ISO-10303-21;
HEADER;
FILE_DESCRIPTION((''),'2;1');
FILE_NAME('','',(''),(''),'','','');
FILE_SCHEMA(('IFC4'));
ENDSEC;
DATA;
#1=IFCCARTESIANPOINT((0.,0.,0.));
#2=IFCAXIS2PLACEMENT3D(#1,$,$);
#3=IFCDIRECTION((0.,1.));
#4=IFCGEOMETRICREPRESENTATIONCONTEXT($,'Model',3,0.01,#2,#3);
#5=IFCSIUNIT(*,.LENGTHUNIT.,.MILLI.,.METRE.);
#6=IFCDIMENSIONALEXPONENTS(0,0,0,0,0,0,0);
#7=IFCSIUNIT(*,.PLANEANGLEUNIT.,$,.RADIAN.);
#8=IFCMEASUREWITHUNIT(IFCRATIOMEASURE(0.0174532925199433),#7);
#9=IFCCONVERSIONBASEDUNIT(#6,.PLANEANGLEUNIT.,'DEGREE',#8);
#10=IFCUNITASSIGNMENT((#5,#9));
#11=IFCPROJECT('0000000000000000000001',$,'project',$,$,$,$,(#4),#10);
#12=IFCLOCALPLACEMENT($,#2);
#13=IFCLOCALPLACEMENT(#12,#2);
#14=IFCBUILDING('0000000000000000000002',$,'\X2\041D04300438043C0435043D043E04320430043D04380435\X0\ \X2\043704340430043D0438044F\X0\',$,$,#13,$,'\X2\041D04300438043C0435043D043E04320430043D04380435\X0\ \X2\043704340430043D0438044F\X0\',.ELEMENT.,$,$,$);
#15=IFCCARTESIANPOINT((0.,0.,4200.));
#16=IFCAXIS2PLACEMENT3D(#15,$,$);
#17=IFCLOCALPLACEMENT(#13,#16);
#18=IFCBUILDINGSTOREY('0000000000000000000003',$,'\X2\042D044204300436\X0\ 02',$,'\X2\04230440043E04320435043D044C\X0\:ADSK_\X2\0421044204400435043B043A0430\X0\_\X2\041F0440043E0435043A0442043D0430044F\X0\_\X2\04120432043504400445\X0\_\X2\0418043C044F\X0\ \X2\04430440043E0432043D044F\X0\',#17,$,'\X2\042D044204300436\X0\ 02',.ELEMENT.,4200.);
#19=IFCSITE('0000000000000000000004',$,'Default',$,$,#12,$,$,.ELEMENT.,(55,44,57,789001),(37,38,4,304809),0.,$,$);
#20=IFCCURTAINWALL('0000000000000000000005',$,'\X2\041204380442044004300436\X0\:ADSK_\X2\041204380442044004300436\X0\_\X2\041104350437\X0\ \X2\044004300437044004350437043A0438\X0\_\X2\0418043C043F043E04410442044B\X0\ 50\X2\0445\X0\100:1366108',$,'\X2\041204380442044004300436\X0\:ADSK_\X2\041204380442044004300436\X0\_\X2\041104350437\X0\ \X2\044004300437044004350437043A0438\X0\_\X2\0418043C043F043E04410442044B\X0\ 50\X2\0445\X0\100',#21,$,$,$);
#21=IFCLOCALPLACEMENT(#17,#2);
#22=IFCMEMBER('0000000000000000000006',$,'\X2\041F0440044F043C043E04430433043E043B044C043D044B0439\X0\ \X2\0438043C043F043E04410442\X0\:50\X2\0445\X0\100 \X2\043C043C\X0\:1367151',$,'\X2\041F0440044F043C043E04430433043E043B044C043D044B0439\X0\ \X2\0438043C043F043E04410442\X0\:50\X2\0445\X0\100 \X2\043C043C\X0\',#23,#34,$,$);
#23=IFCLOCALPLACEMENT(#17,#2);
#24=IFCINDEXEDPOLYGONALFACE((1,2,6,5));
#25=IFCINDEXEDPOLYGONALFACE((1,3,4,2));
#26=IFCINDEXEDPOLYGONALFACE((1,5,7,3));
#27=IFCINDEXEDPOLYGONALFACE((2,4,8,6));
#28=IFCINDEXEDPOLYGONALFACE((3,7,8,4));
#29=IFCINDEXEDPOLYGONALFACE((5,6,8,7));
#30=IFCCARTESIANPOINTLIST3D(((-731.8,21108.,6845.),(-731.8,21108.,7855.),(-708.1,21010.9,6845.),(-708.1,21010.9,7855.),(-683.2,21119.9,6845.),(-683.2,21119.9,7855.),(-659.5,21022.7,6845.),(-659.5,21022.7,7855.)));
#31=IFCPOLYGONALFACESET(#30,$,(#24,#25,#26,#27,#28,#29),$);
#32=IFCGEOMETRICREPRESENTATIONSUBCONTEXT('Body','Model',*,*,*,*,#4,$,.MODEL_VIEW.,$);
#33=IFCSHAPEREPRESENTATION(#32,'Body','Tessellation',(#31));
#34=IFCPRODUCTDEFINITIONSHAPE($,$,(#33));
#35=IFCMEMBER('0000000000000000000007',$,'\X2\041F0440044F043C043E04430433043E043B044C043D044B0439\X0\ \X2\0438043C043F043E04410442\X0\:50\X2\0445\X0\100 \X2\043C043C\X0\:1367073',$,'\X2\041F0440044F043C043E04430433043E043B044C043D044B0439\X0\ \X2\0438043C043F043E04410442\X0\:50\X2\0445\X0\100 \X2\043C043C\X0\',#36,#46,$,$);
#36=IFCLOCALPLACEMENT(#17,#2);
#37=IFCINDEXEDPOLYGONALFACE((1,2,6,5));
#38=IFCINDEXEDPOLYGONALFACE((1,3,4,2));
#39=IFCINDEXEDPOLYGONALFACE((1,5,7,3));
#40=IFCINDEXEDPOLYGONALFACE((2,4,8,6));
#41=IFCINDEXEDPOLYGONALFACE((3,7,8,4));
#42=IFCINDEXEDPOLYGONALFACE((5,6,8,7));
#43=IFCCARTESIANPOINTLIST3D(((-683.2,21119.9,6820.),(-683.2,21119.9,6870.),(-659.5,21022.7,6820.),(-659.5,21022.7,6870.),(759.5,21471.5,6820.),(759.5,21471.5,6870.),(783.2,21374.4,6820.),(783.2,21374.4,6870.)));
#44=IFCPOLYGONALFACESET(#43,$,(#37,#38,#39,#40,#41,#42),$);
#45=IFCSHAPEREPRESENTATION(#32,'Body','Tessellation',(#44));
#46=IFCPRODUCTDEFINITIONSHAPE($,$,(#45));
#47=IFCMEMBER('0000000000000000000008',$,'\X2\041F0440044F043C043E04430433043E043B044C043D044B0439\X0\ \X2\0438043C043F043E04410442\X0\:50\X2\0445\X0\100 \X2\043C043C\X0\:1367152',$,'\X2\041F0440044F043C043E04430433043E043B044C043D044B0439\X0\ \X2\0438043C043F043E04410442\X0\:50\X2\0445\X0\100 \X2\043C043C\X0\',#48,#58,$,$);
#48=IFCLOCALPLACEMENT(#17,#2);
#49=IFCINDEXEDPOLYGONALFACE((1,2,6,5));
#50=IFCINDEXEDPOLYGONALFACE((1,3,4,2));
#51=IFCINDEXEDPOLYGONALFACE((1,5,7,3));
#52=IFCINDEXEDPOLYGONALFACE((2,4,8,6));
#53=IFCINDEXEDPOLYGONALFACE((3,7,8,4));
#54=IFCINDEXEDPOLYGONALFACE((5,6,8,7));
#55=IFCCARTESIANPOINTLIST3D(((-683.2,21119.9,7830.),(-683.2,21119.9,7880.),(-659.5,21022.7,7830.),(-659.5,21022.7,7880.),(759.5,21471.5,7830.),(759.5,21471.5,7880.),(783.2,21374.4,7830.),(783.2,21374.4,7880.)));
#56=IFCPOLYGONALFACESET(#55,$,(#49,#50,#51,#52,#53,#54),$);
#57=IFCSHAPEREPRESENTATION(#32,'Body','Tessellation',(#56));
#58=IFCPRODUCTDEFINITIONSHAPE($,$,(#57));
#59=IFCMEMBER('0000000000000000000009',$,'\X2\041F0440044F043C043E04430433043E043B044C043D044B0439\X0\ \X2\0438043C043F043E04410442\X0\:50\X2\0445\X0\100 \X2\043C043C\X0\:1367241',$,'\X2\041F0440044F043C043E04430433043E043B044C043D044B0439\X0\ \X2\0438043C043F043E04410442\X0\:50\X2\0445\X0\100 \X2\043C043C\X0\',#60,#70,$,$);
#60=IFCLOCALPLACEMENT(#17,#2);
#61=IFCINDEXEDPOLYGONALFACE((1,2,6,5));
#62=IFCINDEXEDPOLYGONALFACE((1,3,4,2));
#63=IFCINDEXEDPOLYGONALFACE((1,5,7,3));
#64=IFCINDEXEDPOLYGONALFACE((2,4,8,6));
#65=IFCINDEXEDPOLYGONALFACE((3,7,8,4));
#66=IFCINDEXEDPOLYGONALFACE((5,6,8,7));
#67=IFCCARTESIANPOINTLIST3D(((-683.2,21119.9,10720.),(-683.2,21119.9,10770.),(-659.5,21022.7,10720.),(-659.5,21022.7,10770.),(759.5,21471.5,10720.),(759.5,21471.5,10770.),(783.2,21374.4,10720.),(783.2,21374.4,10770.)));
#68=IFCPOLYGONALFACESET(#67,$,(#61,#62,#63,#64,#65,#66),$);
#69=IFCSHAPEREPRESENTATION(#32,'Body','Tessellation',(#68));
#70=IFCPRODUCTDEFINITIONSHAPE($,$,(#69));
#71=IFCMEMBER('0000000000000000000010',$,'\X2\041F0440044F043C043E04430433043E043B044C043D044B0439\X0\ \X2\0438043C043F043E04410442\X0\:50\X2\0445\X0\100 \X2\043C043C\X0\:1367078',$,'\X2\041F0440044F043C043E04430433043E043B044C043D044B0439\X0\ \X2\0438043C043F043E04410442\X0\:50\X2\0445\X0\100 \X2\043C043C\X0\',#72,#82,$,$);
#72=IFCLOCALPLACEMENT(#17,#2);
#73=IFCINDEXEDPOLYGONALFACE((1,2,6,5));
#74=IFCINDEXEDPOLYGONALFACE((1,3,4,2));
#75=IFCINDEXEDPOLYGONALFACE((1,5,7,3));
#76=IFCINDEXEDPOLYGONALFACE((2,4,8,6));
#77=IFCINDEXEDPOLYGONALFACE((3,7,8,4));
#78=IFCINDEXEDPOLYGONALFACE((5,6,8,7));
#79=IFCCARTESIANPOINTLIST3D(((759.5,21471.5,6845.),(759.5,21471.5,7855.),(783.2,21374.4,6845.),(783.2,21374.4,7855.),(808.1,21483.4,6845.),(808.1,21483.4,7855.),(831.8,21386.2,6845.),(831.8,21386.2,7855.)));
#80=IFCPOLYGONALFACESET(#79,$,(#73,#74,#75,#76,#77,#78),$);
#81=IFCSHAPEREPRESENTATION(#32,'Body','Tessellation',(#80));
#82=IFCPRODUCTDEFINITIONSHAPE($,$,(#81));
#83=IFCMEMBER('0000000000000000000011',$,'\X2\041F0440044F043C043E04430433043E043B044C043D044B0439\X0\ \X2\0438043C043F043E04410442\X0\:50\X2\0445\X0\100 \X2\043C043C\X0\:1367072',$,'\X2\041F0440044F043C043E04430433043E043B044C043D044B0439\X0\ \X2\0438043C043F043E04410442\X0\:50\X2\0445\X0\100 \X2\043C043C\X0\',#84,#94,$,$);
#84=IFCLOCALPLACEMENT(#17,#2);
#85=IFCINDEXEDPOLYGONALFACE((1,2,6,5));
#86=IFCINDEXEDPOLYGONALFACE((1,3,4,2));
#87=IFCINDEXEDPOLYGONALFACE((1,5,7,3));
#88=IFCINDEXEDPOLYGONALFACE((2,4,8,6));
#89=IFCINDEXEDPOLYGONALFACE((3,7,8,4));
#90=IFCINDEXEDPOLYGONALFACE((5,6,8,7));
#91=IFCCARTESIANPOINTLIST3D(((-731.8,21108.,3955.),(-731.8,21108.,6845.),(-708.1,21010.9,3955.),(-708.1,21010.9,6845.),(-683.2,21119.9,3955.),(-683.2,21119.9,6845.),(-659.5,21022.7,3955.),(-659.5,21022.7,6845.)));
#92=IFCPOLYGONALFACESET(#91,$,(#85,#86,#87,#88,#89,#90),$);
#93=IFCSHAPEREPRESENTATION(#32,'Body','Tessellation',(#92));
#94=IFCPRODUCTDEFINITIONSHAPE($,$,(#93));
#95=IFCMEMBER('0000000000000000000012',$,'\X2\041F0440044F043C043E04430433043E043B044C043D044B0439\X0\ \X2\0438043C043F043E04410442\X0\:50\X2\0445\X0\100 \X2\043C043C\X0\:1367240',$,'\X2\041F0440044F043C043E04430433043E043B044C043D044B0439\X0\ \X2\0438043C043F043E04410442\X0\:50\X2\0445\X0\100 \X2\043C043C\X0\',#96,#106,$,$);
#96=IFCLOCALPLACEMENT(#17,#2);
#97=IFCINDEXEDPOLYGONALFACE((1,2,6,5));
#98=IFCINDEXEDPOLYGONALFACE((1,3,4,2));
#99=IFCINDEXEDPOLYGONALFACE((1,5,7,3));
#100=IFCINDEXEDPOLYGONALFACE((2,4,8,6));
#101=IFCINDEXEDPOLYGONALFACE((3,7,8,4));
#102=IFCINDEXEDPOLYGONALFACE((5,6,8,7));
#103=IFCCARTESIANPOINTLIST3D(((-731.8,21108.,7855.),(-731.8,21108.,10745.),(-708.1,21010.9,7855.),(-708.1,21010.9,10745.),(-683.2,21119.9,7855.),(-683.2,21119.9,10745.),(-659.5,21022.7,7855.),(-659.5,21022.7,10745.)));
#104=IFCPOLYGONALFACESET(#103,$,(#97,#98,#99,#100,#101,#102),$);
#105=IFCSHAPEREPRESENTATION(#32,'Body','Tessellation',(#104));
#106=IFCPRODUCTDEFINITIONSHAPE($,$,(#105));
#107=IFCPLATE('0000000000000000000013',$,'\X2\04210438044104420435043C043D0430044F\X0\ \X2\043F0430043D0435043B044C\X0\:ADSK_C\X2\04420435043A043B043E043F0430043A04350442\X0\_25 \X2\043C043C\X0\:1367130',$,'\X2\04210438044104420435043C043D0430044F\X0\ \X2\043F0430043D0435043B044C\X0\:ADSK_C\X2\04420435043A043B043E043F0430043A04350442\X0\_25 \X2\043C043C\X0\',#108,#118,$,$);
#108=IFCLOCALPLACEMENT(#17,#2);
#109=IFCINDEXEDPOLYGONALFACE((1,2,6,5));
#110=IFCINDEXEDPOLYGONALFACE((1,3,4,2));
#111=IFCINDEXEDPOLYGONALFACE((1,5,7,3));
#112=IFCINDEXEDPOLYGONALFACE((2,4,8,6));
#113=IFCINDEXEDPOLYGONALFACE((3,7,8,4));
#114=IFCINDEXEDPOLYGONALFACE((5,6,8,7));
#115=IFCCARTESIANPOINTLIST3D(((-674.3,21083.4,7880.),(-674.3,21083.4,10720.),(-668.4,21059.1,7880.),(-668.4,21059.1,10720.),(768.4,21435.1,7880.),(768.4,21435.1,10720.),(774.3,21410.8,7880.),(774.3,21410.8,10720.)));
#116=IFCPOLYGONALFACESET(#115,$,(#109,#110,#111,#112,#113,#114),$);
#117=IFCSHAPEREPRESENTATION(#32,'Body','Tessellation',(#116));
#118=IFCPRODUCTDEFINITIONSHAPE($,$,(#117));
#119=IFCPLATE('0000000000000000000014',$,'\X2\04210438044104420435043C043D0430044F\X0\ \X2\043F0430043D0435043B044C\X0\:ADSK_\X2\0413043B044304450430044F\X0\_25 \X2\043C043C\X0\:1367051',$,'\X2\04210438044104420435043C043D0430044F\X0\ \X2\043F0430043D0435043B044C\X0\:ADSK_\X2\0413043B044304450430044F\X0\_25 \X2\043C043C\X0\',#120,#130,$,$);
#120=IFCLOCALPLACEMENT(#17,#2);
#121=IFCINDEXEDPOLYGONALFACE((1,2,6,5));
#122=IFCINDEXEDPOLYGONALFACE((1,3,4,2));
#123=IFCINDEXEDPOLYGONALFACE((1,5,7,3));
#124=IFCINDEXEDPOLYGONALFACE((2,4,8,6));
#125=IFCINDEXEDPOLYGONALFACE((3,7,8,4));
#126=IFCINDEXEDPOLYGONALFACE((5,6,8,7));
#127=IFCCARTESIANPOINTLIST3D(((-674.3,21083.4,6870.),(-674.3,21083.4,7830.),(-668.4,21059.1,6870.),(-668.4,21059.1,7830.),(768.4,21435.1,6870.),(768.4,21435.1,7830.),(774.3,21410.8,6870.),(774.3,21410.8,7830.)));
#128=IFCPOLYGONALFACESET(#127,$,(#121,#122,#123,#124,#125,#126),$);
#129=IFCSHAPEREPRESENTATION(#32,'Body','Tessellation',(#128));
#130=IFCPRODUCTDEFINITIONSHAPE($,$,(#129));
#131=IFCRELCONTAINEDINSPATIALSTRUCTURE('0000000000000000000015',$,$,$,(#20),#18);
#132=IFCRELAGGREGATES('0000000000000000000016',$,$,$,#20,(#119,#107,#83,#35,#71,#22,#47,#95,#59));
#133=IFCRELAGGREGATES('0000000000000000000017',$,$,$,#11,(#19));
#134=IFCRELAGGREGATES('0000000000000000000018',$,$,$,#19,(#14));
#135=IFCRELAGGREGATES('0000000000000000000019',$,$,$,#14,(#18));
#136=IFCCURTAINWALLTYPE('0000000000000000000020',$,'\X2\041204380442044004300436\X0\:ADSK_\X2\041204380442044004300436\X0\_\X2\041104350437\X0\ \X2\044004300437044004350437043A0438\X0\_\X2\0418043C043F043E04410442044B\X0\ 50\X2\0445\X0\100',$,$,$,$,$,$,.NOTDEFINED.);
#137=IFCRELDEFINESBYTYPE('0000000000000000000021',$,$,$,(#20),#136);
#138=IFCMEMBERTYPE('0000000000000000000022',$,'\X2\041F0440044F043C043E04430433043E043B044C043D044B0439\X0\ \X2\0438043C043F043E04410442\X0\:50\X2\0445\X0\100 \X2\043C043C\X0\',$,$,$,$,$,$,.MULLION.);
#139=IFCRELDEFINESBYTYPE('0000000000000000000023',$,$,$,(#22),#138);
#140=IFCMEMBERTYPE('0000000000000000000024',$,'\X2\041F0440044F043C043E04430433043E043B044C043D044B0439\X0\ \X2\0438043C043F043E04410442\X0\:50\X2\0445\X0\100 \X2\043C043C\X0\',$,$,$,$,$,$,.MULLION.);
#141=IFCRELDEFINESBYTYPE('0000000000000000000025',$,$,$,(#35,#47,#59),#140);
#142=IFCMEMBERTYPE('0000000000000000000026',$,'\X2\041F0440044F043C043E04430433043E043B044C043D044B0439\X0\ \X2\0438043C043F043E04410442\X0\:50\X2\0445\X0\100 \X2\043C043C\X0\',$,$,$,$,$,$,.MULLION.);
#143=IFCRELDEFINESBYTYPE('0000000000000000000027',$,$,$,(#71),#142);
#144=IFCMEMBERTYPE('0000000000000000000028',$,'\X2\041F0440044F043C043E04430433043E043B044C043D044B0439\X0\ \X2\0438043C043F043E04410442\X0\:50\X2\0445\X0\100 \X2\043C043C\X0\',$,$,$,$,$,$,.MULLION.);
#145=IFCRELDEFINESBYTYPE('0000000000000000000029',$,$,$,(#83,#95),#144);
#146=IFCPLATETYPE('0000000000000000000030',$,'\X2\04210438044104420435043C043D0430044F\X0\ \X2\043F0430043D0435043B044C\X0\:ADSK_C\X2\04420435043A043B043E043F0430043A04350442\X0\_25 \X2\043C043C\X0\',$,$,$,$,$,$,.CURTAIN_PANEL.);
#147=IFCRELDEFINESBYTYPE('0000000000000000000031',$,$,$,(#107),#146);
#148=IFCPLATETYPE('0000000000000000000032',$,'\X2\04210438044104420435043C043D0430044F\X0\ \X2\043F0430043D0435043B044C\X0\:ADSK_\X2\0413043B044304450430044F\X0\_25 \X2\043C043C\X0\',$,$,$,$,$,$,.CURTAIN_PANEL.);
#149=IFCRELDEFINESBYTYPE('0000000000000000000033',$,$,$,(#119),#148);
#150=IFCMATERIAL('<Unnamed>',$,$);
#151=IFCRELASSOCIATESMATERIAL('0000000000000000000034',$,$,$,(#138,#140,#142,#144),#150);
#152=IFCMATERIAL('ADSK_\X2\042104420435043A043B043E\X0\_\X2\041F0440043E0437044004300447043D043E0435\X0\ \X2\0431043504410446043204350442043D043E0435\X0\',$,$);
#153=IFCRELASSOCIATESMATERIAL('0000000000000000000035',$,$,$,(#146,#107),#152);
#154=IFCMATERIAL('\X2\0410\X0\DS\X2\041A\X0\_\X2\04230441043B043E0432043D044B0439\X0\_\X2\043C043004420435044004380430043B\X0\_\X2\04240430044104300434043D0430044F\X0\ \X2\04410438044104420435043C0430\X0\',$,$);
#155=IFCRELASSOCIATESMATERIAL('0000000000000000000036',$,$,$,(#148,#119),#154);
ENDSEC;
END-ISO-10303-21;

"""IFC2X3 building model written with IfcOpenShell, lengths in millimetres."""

from ifc_helpers import new_model, entity, si_unit, converted_unit, direction, frame, frame_2d, origin, origin_2d_with_axis, place, context, subcontext, project, spatial, rectangle, extrude, source, transform, mapped, material, type_object, type_shapes, element, aggregate, save


model = new_model("IFC2X3")

# Units and contexts
model_context = context("Model", 3, precision=0.01, world=origin(), true_north=direction((0.0, 1.0)))
body_context = subcontext(model_context, "Body", "Model", "MODEL_VIEW")
ifc_project = project(units=[si_unit("LENGTHUNIT", "METRE", prefix="MILLI"), converted_unit("PLANEANGLEUNIT", "DEGREE", entity("IfcRatioMeasure", 0.0174532925199433), si_unit("PLANEANGLEUNIT", "RADIAN"), dimensions=[0, 0, 0, 0, 0, 0, 0])], contexts=[model_context])

# Site, building, storey
site_placement = place(None, origin())
site = spatial("IfcSite", under=ifc_project, at=site_placement, Name="Default", CompositionType="ELEMENT", RefLatitude=(55, 44, 57, 789001), RefLongitude=(37, 38, 4, 304809), RefElevation=0.0)
building_placement = place(site_placement, origin())
building = spatial("IfcBuilding", under=site, at=building_placement, Name="Наименование здания", LongName="Наименование здания", CompositionType="ELEMENT")
storey_placement = place(building_placement, frame((0.0, 0.0, 4200.0)))
storey = spatial("IfcBuildingStorey", under=building, at=storey_placement, Name="Этаж 02", ObjectType="Уровень:ADSK_Стрелка_Проектная_Вверх_Имя уровня", LongName="Этаж 02", CompositionType="ELEMENT", Elevation=4200.0)

# Curtain wall, members, plates
curtain_wall_type = type_object("IfcCurtainWallType", Name="Витраж:ADSK_Витраж_Без разрезки_Импосты 50х100", PredefinedType="NOTDEFINED")
curtain_wall_placement = place(storey_placement, frame((0.0, 0.0, -4200.0)))
curtain_wall = element("IfcCurtainWall", 1, at=curtain_wall_placement, inside=storey, type_object=curtain_wall_type, Name="Витраж:ADSK_Витраж_Без разрезки_Импосты 50х100:1366108", ObjectType="Витраж:ADSK_Витраж_Без разрезки_Импосты 50х100")
ifc_material_1 = material(Name="<Unnamed>")
member_type_1 = type_object("IfcMemberType", Name="Прямоугольный импост:50х100 мм", PredefinedType="MULLION", material=ifc_material_1)
shared_shape_1 = source(origin(), body_context, "Body", "SweptSolid", [
    extrude(rectangle(XDim=100.0, YDim=50.0, at=origin_2d_with_axis()), frame((-25.0, 0.0, -1010.0), z_axis=(0.0, 0.0, 1.0), x_axis=(0.0, -1.0, 0.0)), (0.0, 0.0, 1.0), 1010.0),
])
type_shapes(member_type_1, [shared_shape_1])
member_1_placement = place(storey_placement, frame((-720.0, 21059.4, 7855.0), z_axis=(0.0, 0.0, 1.0), x_axis=(-0.971552, -0.236826, 0.0)))
member_1 = element("IfcMember", 2, at=member_1_placement, type_object=member_type_1, Name="Прямоугольный импост:50х100 мм:1367151", ObjectType="Прямоугольный импост:50х100 мм", context=body_context, shape_type="MappedRepresentation", body=[
    mapped(shared_shape_1, transform((0.0, 0.0, 0.0), scale=1.0)),
])
member_type_2 = type_object("IfcMemberType", Name="Прямоугольный импост:50х100 мм", PredefinedType="MULLION", material=ifc_material_1)
shared_shape_2 = source(origin(), body_context, "Body", "SweptSolid", [
    extrude(rectangle(XDim=100.0, YDim=50.0, at=origin_2d_with_axis()), frame((0.0, 0.0, -1485.0), z_axis=(0.0, 0.0, 1.0), x_axis=(0.0, -1.0, 0.0)), (0.0, 0.0, 1.0), 1485.0),
])
type_shapes(member_type_2, [shared_shape_2])
member_2_placement = place(storey_placement, frame((771.4, 21423.0, 6845.0), z_axis=(0.971552, 0.236826, 0.0), x_axis=(0.0, 0.0, 1.0)))
member_2 = element("IfcMember", 3, at=member_2_placement, type_object=member_type_2, Name="Прямоугольный импост:50х100 мм:1367073", ObjectType="Прямоугольный импост:50х100 мм", context=body_context, shape_type="MappedRepresentation", body=[
    mapped(shared_shape_2, transform((0.0, 0.0, 0.0), scale=1.0)),
])
member_3_placement = place(storey_placement, frame((771.4, 21423.0, 7855.0), z_axis=(0.971552, 0.236826, 0.0), x_axis=(0.0, 0.0, 1.0)))
member_3 = element("IfcMember", 4, at=member_3_placement, type_object=member_type_2, Name="Прямоугольный импост:50х100 мм:1367152", ObjectType="Прямоугольный импост:50х100 мм", context=body_context, shape_type="MappedRepresentation", body=[
    mapped(shared_shape_2, transform((0.0, 0.0, 0.0), scale=1.0)),
])
member_4_placement = place(storey_placement, frame((771.4, 21423.0, 10745.0), z_axis=(0.971552, 0.236826, 0.0), x_axis=(0.0, 0.0, 1.0)))
member_4 = element("IfcMember", 5, at=member_4_placement, type_object=member_type_2, Name="Прямоугольный импост:50х100 мм:1367241", ObjectType="Прямоугольный импост:50х100 мм", context=body_context, shape_type="MappedRepresentation", body=[
    mapped(shared_shape_2, transform((0.0, 0.0, 0.0), scale=1.0)),
])
member_type_3 = type_object("IfcMemberType", Name="Прямоугольный импост:50х100 мм", PredefinedType="MULLION", material=ifc_material_1)
shared_shape_3 = source(origin(), body_context, "Body", "SweptSolid", [
    extrude(rectangle(XDim=100.0, YDim=50.0, at=origin_2d_with_axis()), frame((0.0, 0.0, -1010.0), z_axis=(0.0, 0.0, 1.0), x_axis=(0.0, -1.0, 0.0)), (0.0, 0.0, 1.0), 1010.0),
])
type_shapes(member_type_3, [shared_shape_3])
member_5_placement = place(storey_placement, frame((795.7, 21428.9, 6845.0), z_axis=(0.0, 0.0, -1.0), x_axis=(0.971552, 0.236826, 0.0)))
member_5 = element("IfcMember", 6, at=member_5_placement, type_object=member_type_3, Name="Прямоугольный импост:50х100 мм:1367078", ObjectType="Прямоугольный импост:50х100 мм", context=body_context, shape_type="MappedRepresentation", body=[
    mapped(shared_shape_3, transform((0.0, 0.0, 0.0), scale=1.0)),
])
member_type_4 = type_object("IfcMemberType", Name="Прямоугольный импост:50х100 мм", PredefinedType="MULLION", material=ifc_material_1)
shared_shape_4 = source(origin(), body_context, "Body", "SweptSolid", [
    extrude(rectangle(XDim=100.0, YDim=50.0, at=origin_2d_with_axis()), frame((-25.0, 0.0, -2890.0), z_axis=(0.0, 0.0, 1.0), x_axis=(0.0, -1.0, 0.0)), (0.0, 0.0, 1.0), 2890.0),
])
type_shapes(member_type_4, [shared_shape_4])
member_6_placement = place(storey_placement, frame((-720.0, 21059.4, 6845.0), z_axis=(0.0, 0.0, 1.0), x_axis=(-0.971552, -0.236826, 0.0)))
member_6 = element("IfcMember", 7, at=member_6_placement, type_object=member_type_4, Name="Прямоугольный импост:50х100 мм:1367072", ObjectType="Прямоугольный импост:50х100 мм", context=body_context, shape_type="MappedRepresentation", body=[
    mapped(shared_shape_4, transform((0.0, 0.0, 0.0), scale=1.0)),
])
member_7_placement = place(storey_placement, frame((-720.0, 21059.4, 10745.0), z_axis=(0.0, 0.0, 1.0), x_axis=(-0.971552, -0.236826, 0.0)))
member_7 = element("IfcMember", 8, at=member_7_placement, type_object=member_type_4, Name="Прямоугольный импост:50х100 мм:1367240", ObjectType="Прямоугольный импост:50х100 мм", context=body_context, shape_type="MappedRepresentation", body=[
    mapped(shared_shape_4, transform((0.0, 0.0, 0.0), scale=1.0)),
])
ifc_material_2 = material(Name="ADSK_Стекло_Прозрачное бесцветное")
plate_type_1 = type_object("IfcPlateType", Name="Системная панель:ADSK_Cтеклопакет_25 мм", PredefinedType="CURTAIN_PANEL", material=ifc_material_2)
shared_shape_5 = source(origin(), body_context, "Body", "SweptSolid", [
    extrude(rectangle(XDim=25.0, YDim=1485.0, at=frame_2d((0.0, 0.0), x_axis=(1.0, 0.0))), frame((0.0, 0.0, 0.0), z_axis=(0.0, 0.0, 1.0), x_axis=(0.0, 1.0, 0.0)), (0.0, 0.0, 1.0), 2840.0),
])
type_shapes(plate_type_1, [shared_shape_5])
plate_1_placement = place(curtain_wall_placement, frame((50.0, 21247.1, 12080.0), z_axis=(0.0, 0.0, 1.0), x_axis=(0.971552, 0.236826, 0.0)))
plate_1 = element("IfcPlate", 9, at=plate_1_placement, type_object=plate_type_1, material=ifc_material_2, Name="Системная панель:ADSK_Cтеклопакет_25 мм:1367130", ObjectType="Системная панель:ADSK_Cтеклопакет_25 мм", context=body_context, shape_type="MappedRepresentation", body=[
    mapped(shared_shape_5, transform((0.0, 0.0, 0.0), scale=1.0)),
])
ifc_material_3 = material(Name="АDSК_Условный_материал_Фасадная система")
plate_type_2 = type_object("IfcPlateType", Name="Системная панель:ADSK_Глухая_25 мм", PredefinedType="CURTAIN_PANEL", material=ifc_material_3)
shared_shape_6 = source(origin(), body_context, "Body", "SweptSolid", [
    extrude(rectangle(XDim=25.0, YDim=1485.0, at=frame_2d((0.0, 0.0), x_axis=(1.0, 0.0))), frame((0.0, 0.0, 0.0), z_axis=(0.0, 0.0, 1.0), x_axis=(0.0, 1.0, 0.0)), (0.0, 0.0, 1.0), 960.0),
])
type_shapes(plate_type_2, [shared_shape_6])
plate_2_placement = place(curtain_wall_placement, frame((50.0, 21247.1, 11070.0), z_axis=(0.0, 0.0, 1.0), x_axis=(0.971552, 0.236826, 0.0)))
plate_2 = element("IfcPlate", 10, at=plate_2_placement, type_object=plate_type_2, material=ifc_material_3, Name="Системная панель:ADSK_Глухая_25 мм:1367051", ObjectType="Системная панель:ADSK_Глухая_25 мм", context=body_context, shape_type="MappedRepresentation", body=[
    mapped(shared_shape_6, transform((0.0, 0.0, 0.0), scale=1.0)),
])
aggregate(curtain_wall, [plate_2, plate_1, member_6, member_2, member_5, member_1, member_3, member_7, member_4])

save(model, "model.ifc")
